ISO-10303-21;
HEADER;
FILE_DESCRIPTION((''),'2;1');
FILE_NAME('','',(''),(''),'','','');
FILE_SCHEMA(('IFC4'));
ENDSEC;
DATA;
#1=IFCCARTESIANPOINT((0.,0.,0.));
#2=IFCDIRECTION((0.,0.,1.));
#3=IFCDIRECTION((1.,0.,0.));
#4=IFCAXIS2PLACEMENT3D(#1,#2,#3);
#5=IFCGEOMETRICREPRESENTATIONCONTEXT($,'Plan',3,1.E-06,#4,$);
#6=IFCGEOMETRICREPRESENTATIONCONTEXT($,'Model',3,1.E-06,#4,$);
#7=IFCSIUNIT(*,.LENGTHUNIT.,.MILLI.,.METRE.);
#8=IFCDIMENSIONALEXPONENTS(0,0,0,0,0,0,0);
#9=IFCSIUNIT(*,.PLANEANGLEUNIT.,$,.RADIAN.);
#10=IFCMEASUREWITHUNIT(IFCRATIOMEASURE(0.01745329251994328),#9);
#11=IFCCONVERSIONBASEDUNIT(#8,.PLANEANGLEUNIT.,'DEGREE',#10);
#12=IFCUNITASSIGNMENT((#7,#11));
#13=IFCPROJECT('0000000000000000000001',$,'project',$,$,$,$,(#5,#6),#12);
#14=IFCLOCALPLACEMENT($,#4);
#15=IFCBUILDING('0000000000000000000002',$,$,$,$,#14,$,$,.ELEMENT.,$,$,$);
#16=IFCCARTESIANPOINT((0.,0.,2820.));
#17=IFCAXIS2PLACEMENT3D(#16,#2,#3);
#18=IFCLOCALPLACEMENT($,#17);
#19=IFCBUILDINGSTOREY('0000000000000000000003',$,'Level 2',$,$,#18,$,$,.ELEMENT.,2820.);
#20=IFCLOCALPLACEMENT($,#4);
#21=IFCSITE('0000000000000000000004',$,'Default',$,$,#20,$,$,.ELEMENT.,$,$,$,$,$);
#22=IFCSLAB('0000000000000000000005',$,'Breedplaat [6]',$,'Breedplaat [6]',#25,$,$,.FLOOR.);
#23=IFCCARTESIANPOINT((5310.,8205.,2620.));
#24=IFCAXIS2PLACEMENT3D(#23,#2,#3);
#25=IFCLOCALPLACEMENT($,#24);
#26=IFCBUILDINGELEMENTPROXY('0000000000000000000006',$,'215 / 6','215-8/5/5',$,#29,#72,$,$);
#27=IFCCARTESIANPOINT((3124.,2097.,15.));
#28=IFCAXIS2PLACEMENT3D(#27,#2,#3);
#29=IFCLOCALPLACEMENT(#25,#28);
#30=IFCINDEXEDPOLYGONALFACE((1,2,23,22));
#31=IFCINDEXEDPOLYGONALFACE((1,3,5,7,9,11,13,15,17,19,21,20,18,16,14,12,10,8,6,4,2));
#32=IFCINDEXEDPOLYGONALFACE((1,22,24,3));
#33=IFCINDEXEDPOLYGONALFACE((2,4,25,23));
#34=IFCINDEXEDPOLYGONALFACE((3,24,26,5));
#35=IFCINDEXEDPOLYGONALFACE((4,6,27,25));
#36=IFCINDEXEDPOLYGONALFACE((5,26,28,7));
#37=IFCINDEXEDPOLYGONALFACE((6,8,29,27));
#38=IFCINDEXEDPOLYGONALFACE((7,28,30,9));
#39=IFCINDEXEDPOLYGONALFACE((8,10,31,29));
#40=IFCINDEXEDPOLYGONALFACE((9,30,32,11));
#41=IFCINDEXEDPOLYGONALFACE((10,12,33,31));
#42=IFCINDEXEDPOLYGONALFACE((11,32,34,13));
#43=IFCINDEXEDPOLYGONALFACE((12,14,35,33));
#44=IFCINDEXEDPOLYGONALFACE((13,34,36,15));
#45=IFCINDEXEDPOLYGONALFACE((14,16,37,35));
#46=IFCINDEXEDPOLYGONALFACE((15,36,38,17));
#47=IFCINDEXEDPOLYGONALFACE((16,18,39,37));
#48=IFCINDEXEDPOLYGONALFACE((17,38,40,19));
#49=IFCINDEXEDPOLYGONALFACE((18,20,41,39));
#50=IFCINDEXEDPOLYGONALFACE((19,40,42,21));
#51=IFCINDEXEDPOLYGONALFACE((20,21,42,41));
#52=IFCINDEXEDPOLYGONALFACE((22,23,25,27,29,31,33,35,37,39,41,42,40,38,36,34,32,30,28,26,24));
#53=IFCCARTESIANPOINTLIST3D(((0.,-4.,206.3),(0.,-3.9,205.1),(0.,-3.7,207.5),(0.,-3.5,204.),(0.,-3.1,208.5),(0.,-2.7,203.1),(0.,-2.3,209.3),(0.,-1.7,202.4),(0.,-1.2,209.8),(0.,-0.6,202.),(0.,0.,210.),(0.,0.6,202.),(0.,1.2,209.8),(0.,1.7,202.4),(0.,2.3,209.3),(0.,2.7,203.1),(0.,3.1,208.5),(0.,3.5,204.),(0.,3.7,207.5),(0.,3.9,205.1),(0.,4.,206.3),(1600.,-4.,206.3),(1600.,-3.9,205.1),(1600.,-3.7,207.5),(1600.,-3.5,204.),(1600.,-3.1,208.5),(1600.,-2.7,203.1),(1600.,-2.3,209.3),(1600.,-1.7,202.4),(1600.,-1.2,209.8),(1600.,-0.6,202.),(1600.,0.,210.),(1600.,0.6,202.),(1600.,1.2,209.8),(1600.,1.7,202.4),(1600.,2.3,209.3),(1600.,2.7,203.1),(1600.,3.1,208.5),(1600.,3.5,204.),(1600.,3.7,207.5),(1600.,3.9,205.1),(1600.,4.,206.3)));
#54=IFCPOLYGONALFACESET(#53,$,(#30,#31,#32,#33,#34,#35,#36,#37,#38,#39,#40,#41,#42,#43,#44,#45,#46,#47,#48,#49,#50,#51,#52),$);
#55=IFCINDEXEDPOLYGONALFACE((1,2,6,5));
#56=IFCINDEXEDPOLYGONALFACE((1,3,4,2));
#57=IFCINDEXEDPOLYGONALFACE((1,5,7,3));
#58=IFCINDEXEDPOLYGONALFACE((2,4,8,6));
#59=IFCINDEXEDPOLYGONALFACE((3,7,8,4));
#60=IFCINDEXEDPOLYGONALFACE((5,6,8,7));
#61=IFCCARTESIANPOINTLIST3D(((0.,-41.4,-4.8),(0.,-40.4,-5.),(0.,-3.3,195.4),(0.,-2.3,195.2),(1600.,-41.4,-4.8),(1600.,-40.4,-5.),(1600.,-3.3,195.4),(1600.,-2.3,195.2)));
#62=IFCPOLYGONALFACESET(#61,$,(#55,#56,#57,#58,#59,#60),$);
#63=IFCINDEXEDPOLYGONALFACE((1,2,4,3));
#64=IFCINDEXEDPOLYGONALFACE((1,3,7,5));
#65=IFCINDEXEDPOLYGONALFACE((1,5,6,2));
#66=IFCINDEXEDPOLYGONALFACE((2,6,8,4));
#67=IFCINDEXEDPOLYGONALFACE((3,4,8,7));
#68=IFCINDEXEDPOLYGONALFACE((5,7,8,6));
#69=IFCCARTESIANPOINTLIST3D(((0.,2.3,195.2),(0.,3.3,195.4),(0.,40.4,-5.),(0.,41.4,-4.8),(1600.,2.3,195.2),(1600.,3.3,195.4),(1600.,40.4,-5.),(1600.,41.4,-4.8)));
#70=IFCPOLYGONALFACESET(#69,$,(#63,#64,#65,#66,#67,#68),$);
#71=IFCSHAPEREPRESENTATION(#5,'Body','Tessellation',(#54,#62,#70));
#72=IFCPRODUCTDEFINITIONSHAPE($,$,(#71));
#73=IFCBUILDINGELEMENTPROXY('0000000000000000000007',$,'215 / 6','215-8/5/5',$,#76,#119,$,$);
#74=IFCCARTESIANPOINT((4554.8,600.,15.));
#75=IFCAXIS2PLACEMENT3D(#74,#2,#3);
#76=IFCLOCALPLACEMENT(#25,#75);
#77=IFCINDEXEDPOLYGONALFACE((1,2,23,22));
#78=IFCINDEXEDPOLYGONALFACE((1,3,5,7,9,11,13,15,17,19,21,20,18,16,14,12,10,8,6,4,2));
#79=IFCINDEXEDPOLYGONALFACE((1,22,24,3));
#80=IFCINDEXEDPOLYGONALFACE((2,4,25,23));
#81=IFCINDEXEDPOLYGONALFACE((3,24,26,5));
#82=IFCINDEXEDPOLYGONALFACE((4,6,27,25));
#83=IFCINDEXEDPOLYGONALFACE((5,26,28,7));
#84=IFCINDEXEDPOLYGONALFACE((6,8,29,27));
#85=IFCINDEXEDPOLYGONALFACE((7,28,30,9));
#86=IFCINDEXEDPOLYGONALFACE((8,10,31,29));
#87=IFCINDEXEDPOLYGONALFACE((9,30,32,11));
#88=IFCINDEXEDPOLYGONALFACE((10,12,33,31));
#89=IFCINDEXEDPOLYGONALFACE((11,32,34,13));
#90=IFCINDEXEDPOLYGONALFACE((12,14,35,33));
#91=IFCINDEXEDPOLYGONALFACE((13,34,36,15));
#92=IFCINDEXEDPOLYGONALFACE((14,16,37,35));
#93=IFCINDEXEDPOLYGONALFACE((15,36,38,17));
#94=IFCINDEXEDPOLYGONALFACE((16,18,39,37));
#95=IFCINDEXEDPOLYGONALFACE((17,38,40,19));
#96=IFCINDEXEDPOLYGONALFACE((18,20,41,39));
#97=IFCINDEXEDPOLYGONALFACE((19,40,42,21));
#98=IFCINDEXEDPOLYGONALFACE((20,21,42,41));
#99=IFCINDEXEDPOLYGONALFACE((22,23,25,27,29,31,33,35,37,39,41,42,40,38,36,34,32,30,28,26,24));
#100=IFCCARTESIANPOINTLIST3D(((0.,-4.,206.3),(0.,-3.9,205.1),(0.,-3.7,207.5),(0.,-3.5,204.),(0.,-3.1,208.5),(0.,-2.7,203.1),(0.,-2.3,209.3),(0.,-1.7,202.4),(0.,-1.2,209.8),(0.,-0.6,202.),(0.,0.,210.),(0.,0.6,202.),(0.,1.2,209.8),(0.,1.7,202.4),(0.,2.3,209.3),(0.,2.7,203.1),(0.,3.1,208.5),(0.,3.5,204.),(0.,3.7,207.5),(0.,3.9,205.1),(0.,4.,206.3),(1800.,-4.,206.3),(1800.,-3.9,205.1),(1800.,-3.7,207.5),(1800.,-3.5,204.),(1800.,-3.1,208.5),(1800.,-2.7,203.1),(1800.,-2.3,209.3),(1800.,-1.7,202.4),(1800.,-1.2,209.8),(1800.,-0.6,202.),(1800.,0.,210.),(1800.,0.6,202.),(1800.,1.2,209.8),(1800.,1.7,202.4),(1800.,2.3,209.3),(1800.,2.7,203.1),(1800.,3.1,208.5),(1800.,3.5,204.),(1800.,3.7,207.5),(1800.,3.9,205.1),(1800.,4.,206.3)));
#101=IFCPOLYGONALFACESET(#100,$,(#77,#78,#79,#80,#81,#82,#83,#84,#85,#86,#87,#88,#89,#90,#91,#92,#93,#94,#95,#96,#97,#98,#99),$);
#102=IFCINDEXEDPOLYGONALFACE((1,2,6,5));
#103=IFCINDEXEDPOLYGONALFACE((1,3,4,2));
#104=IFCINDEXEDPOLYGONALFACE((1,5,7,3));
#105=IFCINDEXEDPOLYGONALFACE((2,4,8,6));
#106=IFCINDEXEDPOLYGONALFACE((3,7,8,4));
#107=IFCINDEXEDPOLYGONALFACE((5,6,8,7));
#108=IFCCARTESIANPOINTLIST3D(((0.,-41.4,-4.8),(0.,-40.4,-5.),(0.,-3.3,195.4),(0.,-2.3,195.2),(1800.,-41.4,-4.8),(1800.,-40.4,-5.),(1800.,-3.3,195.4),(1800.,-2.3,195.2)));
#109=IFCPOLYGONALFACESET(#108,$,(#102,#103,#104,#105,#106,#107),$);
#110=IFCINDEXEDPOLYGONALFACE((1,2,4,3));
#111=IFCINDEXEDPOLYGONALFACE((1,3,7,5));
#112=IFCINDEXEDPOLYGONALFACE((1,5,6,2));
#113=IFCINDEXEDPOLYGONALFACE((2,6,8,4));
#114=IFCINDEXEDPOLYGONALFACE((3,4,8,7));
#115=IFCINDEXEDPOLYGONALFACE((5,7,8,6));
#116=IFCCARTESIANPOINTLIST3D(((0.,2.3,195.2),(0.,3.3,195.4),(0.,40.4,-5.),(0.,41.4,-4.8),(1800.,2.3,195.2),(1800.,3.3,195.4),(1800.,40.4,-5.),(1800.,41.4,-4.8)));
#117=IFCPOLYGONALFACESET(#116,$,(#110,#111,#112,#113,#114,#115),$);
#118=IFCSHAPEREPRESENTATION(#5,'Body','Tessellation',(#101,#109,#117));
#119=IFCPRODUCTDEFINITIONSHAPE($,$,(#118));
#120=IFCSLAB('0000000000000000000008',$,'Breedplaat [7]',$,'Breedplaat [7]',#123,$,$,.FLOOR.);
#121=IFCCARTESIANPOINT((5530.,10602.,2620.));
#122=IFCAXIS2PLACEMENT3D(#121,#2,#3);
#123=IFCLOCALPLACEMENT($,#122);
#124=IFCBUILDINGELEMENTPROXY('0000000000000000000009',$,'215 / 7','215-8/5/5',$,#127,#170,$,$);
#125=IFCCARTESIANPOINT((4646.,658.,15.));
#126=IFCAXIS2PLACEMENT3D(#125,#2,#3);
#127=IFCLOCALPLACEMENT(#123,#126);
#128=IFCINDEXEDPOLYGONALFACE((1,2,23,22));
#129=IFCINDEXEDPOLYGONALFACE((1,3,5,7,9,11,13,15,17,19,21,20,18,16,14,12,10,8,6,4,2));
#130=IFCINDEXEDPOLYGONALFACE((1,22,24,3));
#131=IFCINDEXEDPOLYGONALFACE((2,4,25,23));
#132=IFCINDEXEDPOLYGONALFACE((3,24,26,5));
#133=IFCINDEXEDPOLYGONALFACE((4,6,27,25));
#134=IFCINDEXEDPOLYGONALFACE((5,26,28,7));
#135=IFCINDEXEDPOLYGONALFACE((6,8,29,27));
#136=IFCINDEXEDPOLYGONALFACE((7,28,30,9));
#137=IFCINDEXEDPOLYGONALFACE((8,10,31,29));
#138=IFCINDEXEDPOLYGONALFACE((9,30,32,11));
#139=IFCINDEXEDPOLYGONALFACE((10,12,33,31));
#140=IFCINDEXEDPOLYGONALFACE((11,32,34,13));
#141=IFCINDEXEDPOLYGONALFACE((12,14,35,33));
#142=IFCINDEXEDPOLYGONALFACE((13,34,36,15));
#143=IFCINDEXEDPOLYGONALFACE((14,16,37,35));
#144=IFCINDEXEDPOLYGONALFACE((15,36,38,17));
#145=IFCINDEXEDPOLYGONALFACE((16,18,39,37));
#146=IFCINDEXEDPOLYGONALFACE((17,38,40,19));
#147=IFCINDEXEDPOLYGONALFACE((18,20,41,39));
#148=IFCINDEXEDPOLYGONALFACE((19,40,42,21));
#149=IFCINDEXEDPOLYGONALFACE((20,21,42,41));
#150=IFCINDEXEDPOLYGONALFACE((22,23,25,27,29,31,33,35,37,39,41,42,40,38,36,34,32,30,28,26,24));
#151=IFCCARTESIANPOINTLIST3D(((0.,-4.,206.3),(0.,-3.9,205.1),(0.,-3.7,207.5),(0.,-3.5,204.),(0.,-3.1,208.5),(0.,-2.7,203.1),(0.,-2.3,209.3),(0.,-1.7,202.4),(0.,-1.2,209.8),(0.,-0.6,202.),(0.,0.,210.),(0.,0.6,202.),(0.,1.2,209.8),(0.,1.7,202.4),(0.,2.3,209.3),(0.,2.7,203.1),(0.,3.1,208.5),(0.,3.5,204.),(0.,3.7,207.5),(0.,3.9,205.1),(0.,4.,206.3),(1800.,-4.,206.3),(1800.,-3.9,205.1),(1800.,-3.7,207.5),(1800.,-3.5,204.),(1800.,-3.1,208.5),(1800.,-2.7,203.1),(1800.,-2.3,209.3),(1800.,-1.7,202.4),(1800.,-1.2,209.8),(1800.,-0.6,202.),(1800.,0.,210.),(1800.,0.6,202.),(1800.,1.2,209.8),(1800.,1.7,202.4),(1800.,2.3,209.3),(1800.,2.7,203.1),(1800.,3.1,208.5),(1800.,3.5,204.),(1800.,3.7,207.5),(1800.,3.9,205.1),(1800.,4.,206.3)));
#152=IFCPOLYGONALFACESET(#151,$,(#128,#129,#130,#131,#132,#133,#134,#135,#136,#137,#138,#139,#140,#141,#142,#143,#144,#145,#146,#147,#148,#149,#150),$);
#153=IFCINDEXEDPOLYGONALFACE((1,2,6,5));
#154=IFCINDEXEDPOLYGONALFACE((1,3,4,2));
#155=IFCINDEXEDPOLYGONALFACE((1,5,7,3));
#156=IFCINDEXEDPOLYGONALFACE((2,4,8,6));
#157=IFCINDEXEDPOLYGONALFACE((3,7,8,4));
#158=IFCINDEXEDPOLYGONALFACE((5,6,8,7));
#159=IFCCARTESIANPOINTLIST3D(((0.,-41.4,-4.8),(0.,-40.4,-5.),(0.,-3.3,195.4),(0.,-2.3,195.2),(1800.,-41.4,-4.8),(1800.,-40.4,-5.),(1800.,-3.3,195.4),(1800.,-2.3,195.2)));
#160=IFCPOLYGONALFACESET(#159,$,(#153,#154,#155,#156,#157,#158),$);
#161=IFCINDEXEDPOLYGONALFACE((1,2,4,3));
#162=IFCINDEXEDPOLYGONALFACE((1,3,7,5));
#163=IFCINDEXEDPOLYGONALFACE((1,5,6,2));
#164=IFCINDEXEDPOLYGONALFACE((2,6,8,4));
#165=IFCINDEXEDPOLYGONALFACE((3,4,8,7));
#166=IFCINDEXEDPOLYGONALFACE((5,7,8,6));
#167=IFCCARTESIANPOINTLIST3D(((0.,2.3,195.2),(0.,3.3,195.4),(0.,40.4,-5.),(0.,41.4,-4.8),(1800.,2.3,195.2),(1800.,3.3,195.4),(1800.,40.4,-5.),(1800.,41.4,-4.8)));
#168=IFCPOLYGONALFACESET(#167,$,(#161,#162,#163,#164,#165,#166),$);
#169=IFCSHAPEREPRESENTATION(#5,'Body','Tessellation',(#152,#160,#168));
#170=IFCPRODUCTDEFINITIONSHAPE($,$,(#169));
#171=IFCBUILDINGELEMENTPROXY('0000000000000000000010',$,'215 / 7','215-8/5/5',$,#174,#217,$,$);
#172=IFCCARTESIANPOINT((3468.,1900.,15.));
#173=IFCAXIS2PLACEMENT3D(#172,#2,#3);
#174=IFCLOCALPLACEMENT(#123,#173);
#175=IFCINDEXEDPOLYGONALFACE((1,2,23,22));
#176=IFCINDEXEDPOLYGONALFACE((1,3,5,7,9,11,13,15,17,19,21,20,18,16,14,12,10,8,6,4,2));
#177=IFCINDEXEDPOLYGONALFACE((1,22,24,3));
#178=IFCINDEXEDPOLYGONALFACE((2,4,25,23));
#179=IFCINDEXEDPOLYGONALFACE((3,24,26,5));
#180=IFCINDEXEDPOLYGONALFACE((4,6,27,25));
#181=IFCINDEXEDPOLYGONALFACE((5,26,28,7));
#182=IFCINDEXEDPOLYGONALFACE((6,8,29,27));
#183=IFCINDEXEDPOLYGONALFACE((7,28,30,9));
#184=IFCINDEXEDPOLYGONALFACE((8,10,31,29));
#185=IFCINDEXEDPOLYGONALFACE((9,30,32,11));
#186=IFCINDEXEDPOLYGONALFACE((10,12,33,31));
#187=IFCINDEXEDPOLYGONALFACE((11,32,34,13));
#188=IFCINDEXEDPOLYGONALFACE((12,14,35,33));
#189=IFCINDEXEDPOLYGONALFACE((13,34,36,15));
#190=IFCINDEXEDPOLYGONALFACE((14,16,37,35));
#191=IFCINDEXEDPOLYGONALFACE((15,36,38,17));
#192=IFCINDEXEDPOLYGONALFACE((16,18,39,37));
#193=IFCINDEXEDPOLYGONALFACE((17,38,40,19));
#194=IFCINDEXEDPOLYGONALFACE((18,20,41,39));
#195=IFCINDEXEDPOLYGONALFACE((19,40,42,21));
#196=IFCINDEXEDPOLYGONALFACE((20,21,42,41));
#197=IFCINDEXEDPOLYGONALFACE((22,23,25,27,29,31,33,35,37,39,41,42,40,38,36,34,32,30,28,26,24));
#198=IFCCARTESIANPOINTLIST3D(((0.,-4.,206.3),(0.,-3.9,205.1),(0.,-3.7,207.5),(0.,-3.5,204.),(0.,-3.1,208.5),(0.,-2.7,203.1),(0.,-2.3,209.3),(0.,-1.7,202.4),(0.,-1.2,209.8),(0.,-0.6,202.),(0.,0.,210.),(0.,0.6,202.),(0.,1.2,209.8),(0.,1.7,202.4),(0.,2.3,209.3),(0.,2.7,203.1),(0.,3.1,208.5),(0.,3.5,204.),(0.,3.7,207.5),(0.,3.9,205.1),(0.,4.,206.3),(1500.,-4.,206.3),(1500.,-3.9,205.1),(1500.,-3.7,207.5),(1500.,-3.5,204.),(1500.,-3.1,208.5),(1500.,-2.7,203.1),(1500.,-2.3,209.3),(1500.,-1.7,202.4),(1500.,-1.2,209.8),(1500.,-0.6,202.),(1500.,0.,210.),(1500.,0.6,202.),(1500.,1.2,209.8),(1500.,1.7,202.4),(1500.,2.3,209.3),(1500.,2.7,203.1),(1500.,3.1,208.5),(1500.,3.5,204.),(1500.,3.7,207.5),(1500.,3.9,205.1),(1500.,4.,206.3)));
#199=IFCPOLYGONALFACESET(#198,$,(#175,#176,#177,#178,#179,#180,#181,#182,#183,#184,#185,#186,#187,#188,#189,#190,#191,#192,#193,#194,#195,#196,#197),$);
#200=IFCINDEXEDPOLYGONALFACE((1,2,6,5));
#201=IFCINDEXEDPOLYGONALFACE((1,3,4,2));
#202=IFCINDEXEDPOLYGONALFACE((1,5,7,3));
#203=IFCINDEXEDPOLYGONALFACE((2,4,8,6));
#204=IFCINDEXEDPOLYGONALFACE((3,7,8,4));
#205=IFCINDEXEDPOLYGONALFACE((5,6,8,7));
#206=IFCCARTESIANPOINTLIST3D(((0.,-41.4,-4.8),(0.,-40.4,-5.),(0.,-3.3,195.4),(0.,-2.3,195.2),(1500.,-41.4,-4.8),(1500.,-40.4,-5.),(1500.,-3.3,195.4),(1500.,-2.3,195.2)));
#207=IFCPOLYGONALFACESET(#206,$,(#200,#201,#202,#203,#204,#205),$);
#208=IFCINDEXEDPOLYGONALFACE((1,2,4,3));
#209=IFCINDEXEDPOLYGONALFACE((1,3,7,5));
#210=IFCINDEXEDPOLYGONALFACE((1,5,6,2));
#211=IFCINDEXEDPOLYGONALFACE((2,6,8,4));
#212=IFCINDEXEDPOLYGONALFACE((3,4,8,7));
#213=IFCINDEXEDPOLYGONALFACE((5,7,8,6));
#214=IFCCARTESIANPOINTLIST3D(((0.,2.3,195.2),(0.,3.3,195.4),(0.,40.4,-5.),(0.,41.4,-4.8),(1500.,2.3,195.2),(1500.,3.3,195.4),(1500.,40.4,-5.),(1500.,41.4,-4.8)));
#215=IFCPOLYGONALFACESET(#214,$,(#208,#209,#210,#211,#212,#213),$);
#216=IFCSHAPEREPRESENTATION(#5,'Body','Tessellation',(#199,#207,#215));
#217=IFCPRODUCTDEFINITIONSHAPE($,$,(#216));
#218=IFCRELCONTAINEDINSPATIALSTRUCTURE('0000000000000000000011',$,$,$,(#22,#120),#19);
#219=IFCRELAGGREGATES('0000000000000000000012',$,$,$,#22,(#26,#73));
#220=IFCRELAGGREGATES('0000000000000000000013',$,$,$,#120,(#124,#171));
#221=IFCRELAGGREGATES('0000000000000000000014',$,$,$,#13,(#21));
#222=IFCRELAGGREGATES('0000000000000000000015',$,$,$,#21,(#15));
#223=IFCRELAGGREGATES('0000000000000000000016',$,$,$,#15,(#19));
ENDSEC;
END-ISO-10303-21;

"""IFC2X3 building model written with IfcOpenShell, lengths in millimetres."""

from ifc_helpers import new_model, entity, si_unit, converted_unit, frame, origin_with_axes, origin_2d_with_axis, place, context, project, spatial, rectangle, circle, extrude, element, aggregate, save


model = new_model("IFC2X3")

# Units and contexts
plan_context = context("Plan", 3, precision=1e-06, world=origin_with_axes())
model_context = context("Model", 3, precision=1e-06, world=origin_with_axes())
ifc_project = project(units=[si_unit("LENGTHUNIT", "METRE", prefix="MILLI"), converted_unit("PLANEANGLEUNIT", "DEGREE", entity("IfcRatioMeasure", 0.01745329251994328), si_unit("PLANEANGLEUNIT", "RADIAN"), dimensions=[0, 0, 0, 0, 0, 0, 0])], contexts=[plan_context, model_context])

# Site, building, storey
site_placement = place(None, origin_with_axes())
site = spatial("IfcSite", under=ifc_project, at=site_placement, Name="Default", CompositionType="ELEMENT")
building_placement = place(None, origin_with_axes())
building = spatial("IfcBuilding", under=site, at=building_placement, CompositionType="ELEMENT")
storey_placement = place(None, frame((0.0, 0.0, 2820.0), z_axis=(0.0, 0.0, 1.0), x_axis=(1.0, 0.0, 0.0)))
storey = spatial("IfcBuildingStorey", under=building, at=storey_placement, Name="Level 2", CompositionType="ELEMENT", Elevation=2820.0)

# Slabs, building element proxies
slab_1_placement = place(None, frame((5310.0, 8205.0, 2620.0), z_axis=(0.0, 0.0, 1.0), x_axis=(1.0, 0.0, 0.0)))
slab_1 = element("IfcSlab", 1, at=slab_1_placement, inside=storey, Name="Breedplaat [6]", ObjectType="Breedplaat [6]", PredefinedType="FLOOR")
proxy_1_placement = place(slab_1_placement, frame((3124.0, 2097.0, 15.0), z_axis=(0.0, 0.0, 1.0), x_axis=(1.0, 0.0, 0.0)))
proxy_1 = element("IfcBuildingElementProxy", 2, at=proxy_1_placement, Name="215 / 6", Description="215-8/5/5", context=plan_context, shape_type="SweptSolid", body=[
    extrude(circle(Radius=4.0, at=origin_2d_with_axis()), frame((0.0, 0.0, 206.0), z_axis=(1.0, 0.0, 0.0), x_axis=(0.0, 0.0, 1.0)), (0.0, 0.0, 1.0), 1600.0),
    extrude(rectangle(XDim=203.8, YDim=1.0, at=origin_2d_with_axis()), frame((0.0, -21.9, 95.2), z_axis=(1.0, 0.0, 0.0), x_axis=(0.0, 0.187112, 0.982339)), (0.0, 0.0, 1.0), 1600.0),
    extrude(rectangle(XDim=203.8, YDim=1.0, at=origin_2d_with_axis()), frame((0.0, 21.9, 95.2), z_axis=(1.0, 0.0, 0.0), x_axis=(0.0, -0.187112, 0.982339)), (0.0, 0.0, 1.0), 1600.0),
])
proxy_2_placement = place(slab_1_placement, frame((4554.8, 600.0, 15.0), z_axis=(0.0, 0.0, 1.0), x_axis=(1.0, 0.0, 0.0)))
proxy_2 = element("IfcBuildingElementProxy", 3, at=proxy_2_placement, Name="215 / 6", Description="215-8/5/5", context=plan_context, shape_type="SweptSolid", body=[
    extrude(circle(Radius=4.0, at=origin_2d_with_axis()), frame((0.0, 0.0, 206.0), z_axis=(1.0, 0.0, 0.0), x_axis=(0.0, 0.0, 1.0)), (0.0, 0.0, 1.0), 1800.0),
    extrude(rectangle(XDim=203.8, YDim=1.0, at=origin_2d_with_axis()), frame((0.0, -21.9, 95.2), z_axis=(1.0, 0.0, 0.0), x_axis=(0.0, 0.187112, 0.982339)), (0.0, 0.0, 1.0), 1800.0),
    extrude(rectangle(XDim=203.8, YDim=1.0, at=origin_2d_with_axis()), frame((0.0, 21.9, 95.2), z_axis=(1.0, 0.0, 0.0), x_axis=(0.0, -0.187112, 0.982339)), (0.0, 0.0, 1.0), 1800.0),
])
aggregate(slab_1, [proxy_1, proxy_2])
slab_2_placement = place(None, frame((5530.0, 10602.0, 2620.0), z_axis=(0.0, 0.0, 1.0), x_axis=(1.0, 0.0, 0.0)))
slab_2 = element("IfcSlab", 4, at=slab_2_placement, inside=storey, Name="Breedplaat [7]", ObjectType="Breedplaat [7]", PredefinedType="FLOOR")
proxy_3_placement = place(slab_2_placement, frame((4646.0, 658.0, 15.0), z_axis=(0.0, 0.0, 1.0), x_axis=(1.0, 0.0, 0.0)))
proxy_3 = element("IfcBuildingElementProxy", 5, at=proxy_3_placement, Name="215 / 7", Description="215-8/5/5", context=plan_context, shape_type="SweptSolid", body=[
    extrude(circle(Radius=4.0, at=origin_2d_with_axis()), frame((0.0, 0.0, 206.0), z_axis=(1.0, 0.0, 0.0), x_axis=(0.0, 0.0, 1.0)), (0.0, 0.0, 1.0), 1800.0),
    extrude(rectangle(XDim=203.8, YDim=1.0, at=origin_2d_with_axis()), frame((0.0, -21.9, 95.2), z_axis=(1.0, 0.0, 0.0), x_axis=(0.0, 0.187112, 0.982339)), (0.0, 0.0, 1.0), 1800.0),
    extrude(rectangle(XDim=203.8, YDim=1.0, at=origin_2d_with_axis()), frame((0.0, 21.9, 95.2), z_axis=(1.0, 0.0, 0.0), x_axis=(0.0, -0.187112, 0.982339)), (0.0, 0.0, 1.0), 1800.0),
])
proxy_4_placement = place(slab_2_placement, frame((3468.0, 1900.0, 15.0), z_axis=(0.0, 0.0, 1.0), x_axis=(1.0, 0.0, 0.0)))
proxy_4 = element("IfcBuildingElementProxy", 6, at=proxy_4_placement, Name="215 / 7", Description="215-8/5/5", context=plan_context, shape_type="SweptSolid", body=[
    extrude(circle(Radius=4.0, at=origin_2d_with_axis()), frame((0.0, 0.0, 206.0), z_axis=(1.0, 0.0, 0.0), x_axis=(0.0, 0.0, 1.0)), (0.0, 0.0, 1.0), 1500.0),
    extrude(rectangle(XDim=203.8, YDim=1.0, at=origin_2d_with_axis()), frame((0.0, -21.9, 95.2), z_axis=(1.0, 0.0, 0.0), x_axis=(0.0, 0.187112, 0.982339)), (0.0, 0.0, 1.0), 1500.0),
    extrude(rectangle(XDim=203.8, YDim=1.0, at=origin_2d_with_axis()), frame((0.0, 21.9, 95.2), z_axis=(1.0, 0.0, 0.0), x_axis=(0.0, -0.187112, 0.982339)), (0.0, 0.0, 1.0), 1500.0),
])
aggregate(slab_2, [proxy_3, proxy_4])

save(model, "model.ifc")
